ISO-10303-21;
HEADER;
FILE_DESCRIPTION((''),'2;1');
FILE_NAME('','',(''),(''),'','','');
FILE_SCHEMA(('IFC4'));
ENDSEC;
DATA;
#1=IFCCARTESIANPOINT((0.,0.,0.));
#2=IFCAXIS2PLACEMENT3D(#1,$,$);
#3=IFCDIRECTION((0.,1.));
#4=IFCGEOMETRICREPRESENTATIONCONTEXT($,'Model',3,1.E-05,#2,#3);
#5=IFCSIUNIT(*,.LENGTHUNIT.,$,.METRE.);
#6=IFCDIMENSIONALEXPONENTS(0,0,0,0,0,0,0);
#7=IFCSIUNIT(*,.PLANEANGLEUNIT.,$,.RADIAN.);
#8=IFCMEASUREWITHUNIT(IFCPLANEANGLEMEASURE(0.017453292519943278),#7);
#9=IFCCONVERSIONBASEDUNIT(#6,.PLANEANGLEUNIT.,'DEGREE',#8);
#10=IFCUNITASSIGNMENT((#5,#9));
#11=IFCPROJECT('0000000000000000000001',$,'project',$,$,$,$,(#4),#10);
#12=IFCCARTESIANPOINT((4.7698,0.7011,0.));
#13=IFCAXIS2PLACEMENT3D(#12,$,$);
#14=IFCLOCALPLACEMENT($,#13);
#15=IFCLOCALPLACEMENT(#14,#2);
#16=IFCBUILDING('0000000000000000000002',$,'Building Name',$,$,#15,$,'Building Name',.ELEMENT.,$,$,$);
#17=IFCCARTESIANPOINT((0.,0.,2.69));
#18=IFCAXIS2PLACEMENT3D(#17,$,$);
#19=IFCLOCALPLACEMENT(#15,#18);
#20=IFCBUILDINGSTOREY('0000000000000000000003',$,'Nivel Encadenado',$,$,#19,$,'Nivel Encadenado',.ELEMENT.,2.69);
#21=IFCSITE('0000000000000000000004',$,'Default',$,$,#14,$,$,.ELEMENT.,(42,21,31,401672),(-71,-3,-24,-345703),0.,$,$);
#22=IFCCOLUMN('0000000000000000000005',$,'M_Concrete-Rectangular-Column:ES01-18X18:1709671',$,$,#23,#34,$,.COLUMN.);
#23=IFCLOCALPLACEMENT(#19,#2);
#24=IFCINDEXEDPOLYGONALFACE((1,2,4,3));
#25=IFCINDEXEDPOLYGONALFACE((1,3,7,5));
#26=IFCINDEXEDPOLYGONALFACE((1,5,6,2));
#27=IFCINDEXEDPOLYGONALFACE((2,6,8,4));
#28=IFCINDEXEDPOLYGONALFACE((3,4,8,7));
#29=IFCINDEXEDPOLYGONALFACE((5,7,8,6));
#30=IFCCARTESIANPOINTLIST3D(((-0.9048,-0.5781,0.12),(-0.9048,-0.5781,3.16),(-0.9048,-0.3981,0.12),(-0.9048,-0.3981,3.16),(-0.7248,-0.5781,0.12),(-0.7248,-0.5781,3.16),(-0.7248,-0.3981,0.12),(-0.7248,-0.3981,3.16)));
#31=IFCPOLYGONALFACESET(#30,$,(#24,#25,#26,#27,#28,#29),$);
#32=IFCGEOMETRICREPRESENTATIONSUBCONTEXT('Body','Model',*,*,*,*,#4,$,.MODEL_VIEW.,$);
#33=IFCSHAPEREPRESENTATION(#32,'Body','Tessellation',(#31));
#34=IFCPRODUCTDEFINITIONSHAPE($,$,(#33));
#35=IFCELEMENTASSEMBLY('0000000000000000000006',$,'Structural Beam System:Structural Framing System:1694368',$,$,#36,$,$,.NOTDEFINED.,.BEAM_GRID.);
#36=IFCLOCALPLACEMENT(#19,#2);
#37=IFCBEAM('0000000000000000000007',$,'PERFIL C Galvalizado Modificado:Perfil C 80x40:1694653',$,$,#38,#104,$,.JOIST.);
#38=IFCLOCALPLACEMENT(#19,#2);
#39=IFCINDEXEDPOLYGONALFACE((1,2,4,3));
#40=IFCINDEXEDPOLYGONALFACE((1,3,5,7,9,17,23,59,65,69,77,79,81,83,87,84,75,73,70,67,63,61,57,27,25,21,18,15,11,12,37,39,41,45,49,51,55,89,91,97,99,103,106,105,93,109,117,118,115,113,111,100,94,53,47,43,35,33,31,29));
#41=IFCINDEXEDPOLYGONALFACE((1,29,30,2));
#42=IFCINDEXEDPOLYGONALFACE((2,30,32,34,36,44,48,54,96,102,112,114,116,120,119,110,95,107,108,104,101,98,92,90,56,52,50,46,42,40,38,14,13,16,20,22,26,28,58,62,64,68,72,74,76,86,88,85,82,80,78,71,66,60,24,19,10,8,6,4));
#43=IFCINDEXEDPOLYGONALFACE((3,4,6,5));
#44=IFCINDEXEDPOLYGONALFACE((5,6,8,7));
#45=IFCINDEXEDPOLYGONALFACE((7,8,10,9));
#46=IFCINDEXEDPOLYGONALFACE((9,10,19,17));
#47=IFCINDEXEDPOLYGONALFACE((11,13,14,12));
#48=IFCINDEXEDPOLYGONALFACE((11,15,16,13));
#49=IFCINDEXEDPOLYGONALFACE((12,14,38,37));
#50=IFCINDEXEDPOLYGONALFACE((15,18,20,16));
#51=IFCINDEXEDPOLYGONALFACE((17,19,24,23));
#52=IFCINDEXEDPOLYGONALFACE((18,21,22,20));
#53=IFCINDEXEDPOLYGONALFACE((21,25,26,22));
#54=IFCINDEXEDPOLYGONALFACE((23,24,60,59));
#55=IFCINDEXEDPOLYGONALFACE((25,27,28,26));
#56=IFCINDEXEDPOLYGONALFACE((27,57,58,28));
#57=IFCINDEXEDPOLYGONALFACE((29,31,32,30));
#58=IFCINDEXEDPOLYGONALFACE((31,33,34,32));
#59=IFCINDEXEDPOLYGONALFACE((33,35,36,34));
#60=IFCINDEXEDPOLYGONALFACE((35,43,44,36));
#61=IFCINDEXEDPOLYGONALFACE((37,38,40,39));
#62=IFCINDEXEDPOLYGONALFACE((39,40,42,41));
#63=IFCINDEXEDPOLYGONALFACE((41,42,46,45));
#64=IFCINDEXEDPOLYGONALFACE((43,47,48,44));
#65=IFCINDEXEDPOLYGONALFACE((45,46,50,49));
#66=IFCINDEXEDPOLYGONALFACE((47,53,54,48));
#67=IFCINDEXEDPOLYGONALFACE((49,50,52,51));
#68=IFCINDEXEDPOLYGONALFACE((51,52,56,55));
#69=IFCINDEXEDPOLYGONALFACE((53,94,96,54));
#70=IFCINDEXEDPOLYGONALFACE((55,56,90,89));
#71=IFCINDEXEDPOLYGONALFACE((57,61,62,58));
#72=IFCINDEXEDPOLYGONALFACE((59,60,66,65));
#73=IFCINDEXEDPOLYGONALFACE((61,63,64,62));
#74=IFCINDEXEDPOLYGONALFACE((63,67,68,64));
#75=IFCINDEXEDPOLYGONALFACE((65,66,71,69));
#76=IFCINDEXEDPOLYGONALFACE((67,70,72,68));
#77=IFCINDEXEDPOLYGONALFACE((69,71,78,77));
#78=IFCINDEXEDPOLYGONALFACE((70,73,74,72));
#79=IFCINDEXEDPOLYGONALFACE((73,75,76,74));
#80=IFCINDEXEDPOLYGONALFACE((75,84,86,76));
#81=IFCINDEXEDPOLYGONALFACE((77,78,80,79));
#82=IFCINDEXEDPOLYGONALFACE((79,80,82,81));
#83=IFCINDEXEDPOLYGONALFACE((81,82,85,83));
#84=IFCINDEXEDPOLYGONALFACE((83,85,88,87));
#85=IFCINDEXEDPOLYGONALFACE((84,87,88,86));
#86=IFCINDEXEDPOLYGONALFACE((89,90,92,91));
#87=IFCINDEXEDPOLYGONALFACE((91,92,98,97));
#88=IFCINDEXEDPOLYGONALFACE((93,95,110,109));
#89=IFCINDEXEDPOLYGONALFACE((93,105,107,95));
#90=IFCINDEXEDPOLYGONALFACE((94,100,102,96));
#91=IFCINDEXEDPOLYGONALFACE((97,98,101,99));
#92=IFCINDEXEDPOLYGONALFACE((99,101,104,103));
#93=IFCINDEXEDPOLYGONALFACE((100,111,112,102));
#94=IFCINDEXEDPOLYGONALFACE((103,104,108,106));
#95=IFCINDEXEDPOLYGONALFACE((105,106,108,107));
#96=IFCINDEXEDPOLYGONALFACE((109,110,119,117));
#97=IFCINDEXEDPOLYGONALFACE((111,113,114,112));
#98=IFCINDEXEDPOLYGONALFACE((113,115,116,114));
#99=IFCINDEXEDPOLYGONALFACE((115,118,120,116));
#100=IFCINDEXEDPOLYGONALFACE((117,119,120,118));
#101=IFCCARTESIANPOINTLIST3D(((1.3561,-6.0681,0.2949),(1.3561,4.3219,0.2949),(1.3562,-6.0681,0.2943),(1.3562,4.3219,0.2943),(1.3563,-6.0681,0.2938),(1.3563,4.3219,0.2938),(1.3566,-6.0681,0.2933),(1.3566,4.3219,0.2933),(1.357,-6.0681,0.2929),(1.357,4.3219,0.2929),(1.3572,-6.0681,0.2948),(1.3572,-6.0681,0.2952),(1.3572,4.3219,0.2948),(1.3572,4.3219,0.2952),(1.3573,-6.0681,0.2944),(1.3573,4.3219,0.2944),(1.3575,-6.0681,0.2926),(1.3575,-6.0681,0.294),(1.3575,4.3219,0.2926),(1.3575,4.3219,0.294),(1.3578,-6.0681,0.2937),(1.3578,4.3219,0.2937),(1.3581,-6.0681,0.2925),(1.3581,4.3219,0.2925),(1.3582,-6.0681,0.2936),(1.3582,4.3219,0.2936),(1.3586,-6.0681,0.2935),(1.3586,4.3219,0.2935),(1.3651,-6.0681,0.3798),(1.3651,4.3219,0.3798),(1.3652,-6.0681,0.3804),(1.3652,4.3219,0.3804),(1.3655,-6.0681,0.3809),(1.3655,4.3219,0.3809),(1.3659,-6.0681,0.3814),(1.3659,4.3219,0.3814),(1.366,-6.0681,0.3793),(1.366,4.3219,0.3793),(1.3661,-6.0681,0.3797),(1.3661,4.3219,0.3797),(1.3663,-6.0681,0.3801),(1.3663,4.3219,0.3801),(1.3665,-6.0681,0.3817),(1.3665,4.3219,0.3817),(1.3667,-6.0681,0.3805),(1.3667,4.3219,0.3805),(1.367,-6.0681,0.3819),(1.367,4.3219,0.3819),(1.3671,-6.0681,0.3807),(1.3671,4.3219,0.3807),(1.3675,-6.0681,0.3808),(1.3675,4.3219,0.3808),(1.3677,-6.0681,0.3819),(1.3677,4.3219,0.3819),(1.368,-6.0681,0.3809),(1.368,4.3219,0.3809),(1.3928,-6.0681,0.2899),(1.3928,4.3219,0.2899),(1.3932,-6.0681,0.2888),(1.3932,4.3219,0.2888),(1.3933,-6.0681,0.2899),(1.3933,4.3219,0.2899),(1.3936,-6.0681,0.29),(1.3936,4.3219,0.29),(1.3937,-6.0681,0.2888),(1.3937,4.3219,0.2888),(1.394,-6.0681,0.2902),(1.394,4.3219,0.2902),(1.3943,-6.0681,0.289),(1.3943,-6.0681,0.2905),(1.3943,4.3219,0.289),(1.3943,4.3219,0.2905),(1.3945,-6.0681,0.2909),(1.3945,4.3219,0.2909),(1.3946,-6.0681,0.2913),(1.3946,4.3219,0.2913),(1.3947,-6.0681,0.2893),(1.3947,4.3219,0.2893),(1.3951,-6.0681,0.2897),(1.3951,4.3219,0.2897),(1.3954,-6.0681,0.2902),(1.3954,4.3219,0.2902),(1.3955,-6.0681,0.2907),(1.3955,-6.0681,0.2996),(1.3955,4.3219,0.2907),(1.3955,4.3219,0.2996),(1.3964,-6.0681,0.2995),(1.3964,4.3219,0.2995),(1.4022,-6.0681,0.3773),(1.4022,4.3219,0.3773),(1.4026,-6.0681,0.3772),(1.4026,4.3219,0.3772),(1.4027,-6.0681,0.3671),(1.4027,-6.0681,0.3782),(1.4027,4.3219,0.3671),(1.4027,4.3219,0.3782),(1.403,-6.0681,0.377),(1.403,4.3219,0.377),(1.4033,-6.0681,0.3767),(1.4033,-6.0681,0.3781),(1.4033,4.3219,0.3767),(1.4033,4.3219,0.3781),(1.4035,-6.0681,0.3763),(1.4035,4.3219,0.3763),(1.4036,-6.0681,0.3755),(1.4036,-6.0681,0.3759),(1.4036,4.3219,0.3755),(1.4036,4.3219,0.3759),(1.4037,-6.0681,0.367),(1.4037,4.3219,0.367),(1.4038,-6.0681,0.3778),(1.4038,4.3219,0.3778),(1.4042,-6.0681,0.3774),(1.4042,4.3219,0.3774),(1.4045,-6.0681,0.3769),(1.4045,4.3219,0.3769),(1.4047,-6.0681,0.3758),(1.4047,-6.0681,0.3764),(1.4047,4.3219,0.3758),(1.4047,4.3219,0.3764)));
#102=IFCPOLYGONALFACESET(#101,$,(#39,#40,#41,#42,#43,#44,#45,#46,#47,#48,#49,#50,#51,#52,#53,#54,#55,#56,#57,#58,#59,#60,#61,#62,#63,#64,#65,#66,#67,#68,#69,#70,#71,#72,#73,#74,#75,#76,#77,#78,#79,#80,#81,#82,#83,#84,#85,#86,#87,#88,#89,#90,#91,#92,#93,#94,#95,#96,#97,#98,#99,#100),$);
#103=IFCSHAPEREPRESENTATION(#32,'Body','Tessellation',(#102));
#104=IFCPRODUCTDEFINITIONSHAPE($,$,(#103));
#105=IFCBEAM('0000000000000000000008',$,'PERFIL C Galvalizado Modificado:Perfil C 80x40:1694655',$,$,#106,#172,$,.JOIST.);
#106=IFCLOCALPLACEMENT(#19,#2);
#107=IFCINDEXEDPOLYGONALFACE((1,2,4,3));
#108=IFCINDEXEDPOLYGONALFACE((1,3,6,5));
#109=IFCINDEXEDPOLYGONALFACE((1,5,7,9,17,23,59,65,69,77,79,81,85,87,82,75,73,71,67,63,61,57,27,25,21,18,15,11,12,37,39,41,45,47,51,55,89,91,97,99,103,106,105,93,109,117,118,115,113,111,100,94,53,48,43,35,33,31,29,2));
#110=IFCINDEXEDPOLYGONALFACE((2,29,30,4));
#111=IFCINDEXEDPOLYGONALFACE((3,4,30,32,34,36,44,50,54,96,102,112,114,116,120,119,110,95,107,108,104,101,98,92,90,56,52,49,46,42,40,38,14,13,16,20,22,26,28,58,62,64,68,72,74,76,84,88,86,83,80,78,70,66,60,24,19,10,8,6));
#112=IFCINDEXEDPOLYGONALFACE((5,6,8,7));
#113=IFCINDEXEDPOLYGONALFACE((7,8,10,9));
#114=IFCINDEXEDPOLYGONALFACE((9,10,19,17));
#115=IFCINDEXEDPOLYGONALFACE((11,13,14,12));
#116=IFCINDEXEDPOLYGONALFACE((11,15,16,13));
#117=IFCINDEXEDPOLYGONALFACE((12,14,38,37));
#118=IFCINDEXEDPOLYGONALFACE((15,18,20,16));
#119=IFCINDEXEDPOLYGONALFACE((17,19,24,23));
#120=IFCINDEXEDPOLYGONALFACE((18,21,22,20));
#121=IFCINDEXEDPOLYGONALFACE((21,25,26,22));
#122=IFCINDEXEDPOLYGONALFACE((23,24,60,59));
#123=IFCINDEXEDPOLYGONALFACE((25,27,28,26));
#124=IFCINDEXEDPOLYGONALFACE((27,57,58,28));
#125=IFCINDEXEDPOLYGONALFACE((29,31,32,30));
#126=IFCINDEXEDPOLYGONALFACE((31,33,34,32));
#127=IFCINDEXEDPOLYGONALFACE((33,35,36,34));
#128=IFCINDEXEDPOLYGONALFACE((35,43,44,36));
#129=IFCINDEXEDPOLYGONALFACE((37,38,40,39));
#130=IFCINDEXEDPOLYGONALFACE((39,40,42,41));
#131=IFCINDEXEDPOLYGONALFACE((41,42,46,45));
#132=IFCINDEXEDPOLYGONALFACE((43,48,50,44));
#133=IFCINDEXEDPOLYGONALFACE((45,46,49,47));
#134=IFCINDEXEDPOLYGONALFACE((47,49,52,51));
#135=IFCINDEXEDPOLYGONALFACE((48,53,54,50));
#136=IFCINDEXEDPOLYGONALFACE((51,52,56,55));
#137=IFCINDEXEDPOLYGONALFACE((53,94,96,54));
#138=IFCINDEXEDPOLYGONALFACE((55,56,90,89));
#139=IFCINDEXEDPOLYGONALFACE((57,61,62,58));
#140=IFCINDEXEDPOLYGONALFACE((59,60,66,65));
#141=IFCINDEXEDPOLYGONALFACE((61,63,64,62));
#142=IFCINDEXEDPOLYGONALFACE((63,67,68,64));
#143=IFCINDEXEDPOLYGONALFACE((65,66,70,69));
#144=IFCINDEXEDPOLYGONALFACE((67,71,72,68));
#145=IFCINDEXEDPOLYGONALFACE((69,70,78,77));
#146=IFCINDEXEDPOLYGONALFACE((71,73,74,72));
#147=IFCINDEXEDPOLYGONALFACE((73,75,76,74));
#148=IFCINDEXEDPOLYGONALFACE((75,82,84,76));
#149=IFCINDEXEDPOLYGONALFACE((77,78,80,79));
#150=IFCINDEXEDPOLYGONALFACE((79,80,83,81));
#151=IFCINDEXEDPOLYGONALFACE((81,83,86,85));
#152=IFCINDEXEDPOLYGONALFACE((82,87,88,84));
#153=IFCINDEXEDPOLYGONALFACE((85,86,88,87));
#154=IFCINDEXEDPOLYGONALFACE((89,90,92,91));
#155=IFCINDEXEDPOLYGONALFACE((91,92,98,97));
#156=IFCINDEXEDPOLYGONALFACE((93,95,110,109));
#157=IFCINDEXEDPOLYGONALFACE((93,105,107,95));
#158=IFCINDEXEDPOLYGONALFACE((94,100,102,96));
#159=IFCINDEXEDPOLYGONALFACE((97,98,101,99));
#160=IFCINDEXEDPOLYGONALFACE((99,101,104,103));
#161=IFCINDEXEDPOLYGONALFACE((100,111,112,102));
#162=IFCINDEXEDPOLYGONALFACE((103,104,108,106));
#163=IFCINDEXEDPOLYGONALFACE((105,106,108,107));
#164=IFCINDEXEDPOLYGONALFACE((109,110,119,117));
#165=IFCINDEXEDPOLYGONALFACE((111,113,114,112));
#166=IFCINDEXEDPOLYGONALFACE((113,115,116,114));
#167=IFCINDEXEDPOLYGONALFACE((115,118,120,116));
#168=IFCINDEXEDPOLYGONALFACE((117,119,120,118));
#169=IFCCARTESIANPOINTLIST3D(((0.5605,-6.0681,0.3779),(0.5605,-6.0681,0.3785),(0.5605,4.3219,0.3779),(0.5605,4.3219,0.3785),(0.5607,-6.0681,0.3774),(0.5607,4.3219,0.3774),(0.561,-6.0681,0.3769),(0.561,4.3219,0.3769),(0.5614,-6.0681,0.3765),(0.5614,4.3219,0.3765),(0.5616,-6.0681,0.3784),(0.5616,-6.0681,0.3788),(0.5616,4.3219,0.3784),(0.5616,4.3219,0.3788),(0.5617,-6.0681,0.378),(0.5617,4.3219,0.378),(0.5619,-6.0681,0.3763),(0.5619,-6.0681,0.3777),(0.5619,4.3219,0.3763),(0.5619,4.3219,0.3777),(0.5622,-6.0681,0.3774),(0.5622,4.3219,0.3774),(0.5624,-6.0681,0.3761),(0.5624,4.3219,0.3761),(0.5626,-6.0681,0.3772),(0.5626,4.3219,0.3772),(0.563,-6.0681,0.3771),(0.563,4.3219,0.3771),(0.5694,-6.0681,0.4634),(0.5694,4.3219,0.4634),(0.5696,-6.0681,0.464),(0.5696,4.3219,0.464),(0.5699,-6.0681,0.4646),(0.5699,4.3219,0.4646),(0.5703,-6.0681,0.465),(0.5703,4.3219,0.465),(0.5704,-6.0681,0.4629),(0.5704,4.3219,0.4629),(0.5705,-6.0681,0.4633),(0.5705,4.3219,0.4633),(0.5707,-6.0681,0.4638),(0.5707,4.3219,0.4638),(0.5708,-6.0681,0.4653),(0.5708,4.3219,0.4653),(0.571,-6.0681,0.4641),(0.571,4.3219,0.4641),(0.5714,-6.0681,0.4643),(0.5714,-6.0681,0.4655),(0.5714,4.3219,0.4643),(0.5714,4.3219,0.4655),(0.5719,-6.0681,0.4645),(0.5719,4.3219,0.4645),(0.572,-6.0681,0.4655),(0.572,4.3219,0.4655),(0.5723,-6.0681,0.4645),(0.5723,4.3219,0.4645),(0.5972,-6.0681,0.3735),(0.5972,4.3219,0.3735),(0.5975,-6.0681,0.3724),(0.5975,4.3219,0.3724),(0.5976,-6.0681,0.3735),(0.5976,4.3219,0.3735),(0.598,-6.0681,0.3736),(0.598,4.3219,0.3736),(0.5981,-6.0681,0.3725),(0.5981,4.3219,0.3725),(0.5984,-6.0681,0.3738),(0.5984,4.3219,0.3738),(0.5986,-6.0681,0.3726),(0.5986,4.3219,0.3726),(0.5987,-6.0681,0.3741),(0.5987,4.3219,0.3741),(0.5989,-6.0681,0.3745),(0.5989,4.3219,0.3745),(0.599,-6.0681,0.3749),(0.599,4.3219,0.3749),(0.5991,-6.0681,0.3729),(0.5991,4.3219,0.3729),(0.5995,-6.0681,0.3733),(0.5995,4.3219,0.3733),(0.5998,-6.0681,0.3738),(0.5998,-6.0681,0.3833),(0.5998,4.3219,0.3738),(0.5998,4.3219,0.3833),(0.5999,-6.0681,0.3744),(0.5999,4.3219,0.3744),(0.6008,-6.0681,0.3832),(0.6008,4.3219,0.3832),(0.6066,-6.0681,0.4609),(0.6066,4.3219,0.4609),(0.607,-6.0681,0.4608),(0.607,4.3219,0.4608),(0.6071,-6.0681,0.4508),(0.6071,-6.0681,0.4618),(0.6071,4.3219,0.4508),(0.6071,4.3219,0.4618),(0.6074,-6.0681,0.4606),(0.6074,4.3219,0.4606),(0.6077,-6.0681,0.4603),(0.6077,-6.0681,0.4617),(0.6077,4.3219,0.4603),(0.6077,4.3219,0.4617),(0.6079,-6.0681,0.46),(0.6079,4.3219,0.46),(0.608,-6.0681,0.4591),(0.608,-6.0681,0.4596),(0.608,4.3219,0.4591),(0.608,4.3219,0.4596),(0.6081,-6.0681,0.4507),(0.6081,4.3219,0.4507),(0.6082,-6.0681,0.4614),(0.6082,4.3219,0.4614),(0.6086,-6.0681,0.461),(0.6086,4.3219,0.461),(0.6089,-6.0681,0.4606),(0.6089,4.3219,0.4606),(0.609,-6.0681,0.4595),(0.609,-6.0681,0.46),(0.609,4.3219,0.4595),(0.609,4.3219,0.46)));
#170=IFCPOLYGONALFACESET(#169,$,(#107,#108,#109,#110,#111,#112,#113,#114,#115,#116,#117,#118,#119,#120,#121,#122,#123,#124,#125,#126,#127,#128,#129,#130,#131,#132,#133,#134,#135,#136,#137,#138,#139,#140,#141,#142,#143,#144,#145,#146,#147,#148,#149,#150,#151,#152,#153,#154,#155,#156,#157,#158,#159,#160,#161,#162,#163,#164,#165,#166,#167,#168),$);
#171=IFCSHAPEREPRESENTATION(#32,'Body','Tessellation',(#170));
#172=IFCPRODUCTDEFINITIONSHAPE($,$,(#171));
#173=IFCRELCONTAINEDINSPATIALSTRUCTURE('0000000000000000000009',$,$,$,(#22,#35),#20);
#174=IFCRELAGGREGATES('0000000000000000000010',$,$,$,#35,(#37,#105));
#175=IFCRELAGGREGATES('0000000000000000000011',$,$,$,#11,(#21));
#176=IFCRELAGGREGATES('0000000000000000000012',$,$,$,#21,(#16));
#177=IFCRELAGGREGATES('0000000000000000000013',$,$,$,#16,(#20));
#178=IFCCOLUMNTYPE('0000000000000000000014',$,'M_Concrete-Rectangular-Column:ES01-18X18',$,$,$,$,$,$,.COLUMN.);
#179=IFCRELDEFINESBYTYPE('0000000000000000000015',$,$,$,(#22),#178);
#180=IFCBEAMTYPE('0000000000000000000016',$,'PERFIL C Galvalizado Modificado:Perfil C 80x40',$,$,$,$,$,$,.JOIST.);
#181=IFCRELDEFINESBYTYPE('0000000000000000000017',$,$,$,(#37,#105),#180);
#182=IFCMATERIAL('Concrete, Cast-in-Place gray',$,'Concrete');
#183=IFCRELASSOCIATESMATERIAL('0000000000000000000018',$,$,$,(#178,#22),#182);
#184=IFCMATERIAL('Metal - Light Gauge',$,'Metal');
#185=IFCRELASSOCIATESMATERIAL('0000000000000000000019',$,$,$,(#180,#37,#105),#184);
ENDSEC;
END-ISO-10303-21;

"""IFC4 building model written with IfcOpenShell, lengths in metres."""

from ifc_helpers import new_model, entity, si_unit, converted_unit, direction, frame, origin, place, context, subcontext, project, spatial, line, arc, indexed_curve, outline, extrude, source, transform, mapped, material, type_object, type_shapes, element, aggregate, save


model = new_model("IFC4")

# Units and contexts
model_context = context("Model", 3, precision=1e-05, world=origin(), true_north=direction((0.0, 1.0)))
body_context = subcontext(model_context, "Body", "Model", "MODEL_VIEW")
ifc_project = project(units=[si_unit("LENGTHUNIT", "METRE"), converted_unit("PLANEANGLEUNIT", "DEGREE", entity("IfcPlaneAngleMeasure", 0.017453292519943278), si_unit("PLANEANGLEUNIT", "RADIAN"), dimensions=[0, 0, 0, 0, 0, 0, 0])], contexts=[model_context])

# Site, building, storey
site_placement = place(None, frame((4.7698, 0.7011, 0.0)))
site = spatial("IfcSite", under=ifc_project, at=site_placement, Name="Default", CompositionType="ELEMENT", RefLatitude=(42, 21, 31, 401672), RefLongitude=(-71, -3, -24, -345703), RefElevation=0.0)
building_placement = place(site_placement, origin())
building = spatial("IfcBuilding", under=site, at=building_placement, Name="Building Name", LongName="Building Name", CompositionType="ELEMENT")
storey_placement = place(building_placement, frame((0.0, 0.0, 2.69)))
storey = spatial("IfcBuildingStorey", under=building, at=storey_placement, Name="Nivel Encadenado", LongName="Nivel Encadenado", CompositionType="ELEMENT", Elevation=2.69)

# Column
ifc_material_1 = material(Name="Concrete, Cast-in-Place gray", Category="Concrete")
column_type_1 = type_object("IfcColumnType", Name="M_Concrete-Rectangular-Column:ES01-18X18", PredefinedType="COLUMN", material=ifc_material_1)
shared_shape_1 = source(origin(), body_context, "Body", "SweptSolid", [
    extrude(outline(indexed_curve([(-0.09, -0.09), (0.09, -0.09), (0.09, 0.09), (-0.09, 0.09), (-0.09, -0.09)], self_intersect=False)), frame((-0.8148, -0.4881, 2.81), z_axis=(0.0, 0.0, 1.0), x_axis=(-1.0, 0.0, 0.0)), (0.0, 0.0, 1.0), 3.04),
])
type_shapes(column_type_1, [shared_shape_1])
column_1_placement = place(storey_placement, frame((0.0, 0.0, -2.69)))
element("IfcColumn", 1, at=column_1_placement, inside=storey, type_object=column_type_1, material=ifc_material_1, Name="M_Concrete-Rectangular-Column:ES01-18X18:1709671", PredefinedType="COLUMN", context=body_context, shape_type="MappedRepresentation", body=[
    mapped(shared_shape_1, transform((0.0, 0.0, 0.0), scale=1.0)),
])

# Element assembly, beams
assembly_1_placement = place(storey_placement, origin())
assembly_1 = element("IfcElementAssembly", 2, at=assembly_1_placement, inside=storey, Name="Structural Beam System:Structural Framing System:1694368", AssemblyPlace="NOTDEFINED", PredefinedType="BEAM_GRID")
ifc_material_2 = material(Name="Metal - Light Gauge", Category="Metal")
beam_type_1 = type_object("IfcBeamType", Name="PERFIL C Galvalizado Modificado:Perfil C 80x40", PredefinedType="JOIST", material=ifc_material_2)
shared_shape_2 = source(origin(), body_context, "Body", "SweptSolid", [
    extrude(outline(indexed_curve([(-0.0428, -0.0161), (-0.034, -0.0161), (-0.034, -0.0151), (-0.0424, -0.0151), (-0.0435, -0.0146), (-0.044, -0.0135), (-0.044, 0.021), (-0.0435, 0.0222), (-0.0422, 0.0227), (0.0424, 0.0227), (0.0435, 0.0223), (0.0439, 0.0212), (0.0439, -0.0133), (0.0435, -0.0144), (0.0424, -0.0149), (0.0339, -0.0149), (0.0339, -0.0159), (0.0428, -0.0159), (0.0443, -0.0152), (0.0449, -0.0137), (0.0449, 0.0216), (0.0443, 0.0231), (0.0428, 0.0237), (-0.0426, 0.0237), (-0.0443, 0.023), (-0.045, 0.0214), (-0.045, -0.0139), (-0.0443, -0.0154)], segments=[line(1, 2, 3, 4), arc(4, 5, 6), line(6, 7), arc(7, 8, 9), line(9, 10), arc(10, 11, 12), line(12, 13), arc(13, 14, 15), line(15, 16, 17, 18), arc(18, 19, 20), line(20, 21), arc(21, 22, 23), line(23, 24), arc(24, 25, 26), line(26, 27), arc(27, 28, 1)], self_intersect=False)), frame((-5.195, -0.0037, 0.0), z_axis=(1.0, 0.0, 0.0), x_axis=(0.0, 0.0, -1.0)), (0.0, 0.0, 1.0), 10.39),
])
type_shapes(beam_type_1, [shared_shape_2])
beam_1_placement = place(assembly_1_placement, frame((1.3805, -0.8731, 0.3353), z_axis=(0.104528, 0.0, 0.994522), x_axis=(0.0, 1.0, 0.0)))
beam_1 = element("IfcBeam", 3, at=beam_1_placement, type_object=beam_type_1, material=ifc_material_2, Name="PERFIL C Galvalizado Modificado:Perfil C 80x40:1694653", PredefinedType="JOIST", context=body_context, shape_type="MappedRepresentation", body=[
    mapped(shared_shape_2, transform((0.0, 0.0, 0.0), scale=1.0)),
])
beam_2_placement = place(assembly_1_placement, frame((0.5849, -0.8731, 0.419), z_axis=(0.104528, 0.0, 0.994522), x_axis=(0.0, 1.0, 0.0)))
beam_2 = element("IfcBeam", 4, at=beam_2_placement, type_object=beam_type_1, material=ifc_material_2, Name="PERFIL C Galvalizado Modificado:Perfil C 80x40:1694655", PredefinedType="JOIST", context=body_context, shape_type="MappedRepresentation", body=[
    mapped(shared_shape_2, transform((0.0, 0.0, 0.0), scale=1.0)),
])
aggregate(assembly_1, [beam_1, beam_2])

save(model, "model.ifc")
